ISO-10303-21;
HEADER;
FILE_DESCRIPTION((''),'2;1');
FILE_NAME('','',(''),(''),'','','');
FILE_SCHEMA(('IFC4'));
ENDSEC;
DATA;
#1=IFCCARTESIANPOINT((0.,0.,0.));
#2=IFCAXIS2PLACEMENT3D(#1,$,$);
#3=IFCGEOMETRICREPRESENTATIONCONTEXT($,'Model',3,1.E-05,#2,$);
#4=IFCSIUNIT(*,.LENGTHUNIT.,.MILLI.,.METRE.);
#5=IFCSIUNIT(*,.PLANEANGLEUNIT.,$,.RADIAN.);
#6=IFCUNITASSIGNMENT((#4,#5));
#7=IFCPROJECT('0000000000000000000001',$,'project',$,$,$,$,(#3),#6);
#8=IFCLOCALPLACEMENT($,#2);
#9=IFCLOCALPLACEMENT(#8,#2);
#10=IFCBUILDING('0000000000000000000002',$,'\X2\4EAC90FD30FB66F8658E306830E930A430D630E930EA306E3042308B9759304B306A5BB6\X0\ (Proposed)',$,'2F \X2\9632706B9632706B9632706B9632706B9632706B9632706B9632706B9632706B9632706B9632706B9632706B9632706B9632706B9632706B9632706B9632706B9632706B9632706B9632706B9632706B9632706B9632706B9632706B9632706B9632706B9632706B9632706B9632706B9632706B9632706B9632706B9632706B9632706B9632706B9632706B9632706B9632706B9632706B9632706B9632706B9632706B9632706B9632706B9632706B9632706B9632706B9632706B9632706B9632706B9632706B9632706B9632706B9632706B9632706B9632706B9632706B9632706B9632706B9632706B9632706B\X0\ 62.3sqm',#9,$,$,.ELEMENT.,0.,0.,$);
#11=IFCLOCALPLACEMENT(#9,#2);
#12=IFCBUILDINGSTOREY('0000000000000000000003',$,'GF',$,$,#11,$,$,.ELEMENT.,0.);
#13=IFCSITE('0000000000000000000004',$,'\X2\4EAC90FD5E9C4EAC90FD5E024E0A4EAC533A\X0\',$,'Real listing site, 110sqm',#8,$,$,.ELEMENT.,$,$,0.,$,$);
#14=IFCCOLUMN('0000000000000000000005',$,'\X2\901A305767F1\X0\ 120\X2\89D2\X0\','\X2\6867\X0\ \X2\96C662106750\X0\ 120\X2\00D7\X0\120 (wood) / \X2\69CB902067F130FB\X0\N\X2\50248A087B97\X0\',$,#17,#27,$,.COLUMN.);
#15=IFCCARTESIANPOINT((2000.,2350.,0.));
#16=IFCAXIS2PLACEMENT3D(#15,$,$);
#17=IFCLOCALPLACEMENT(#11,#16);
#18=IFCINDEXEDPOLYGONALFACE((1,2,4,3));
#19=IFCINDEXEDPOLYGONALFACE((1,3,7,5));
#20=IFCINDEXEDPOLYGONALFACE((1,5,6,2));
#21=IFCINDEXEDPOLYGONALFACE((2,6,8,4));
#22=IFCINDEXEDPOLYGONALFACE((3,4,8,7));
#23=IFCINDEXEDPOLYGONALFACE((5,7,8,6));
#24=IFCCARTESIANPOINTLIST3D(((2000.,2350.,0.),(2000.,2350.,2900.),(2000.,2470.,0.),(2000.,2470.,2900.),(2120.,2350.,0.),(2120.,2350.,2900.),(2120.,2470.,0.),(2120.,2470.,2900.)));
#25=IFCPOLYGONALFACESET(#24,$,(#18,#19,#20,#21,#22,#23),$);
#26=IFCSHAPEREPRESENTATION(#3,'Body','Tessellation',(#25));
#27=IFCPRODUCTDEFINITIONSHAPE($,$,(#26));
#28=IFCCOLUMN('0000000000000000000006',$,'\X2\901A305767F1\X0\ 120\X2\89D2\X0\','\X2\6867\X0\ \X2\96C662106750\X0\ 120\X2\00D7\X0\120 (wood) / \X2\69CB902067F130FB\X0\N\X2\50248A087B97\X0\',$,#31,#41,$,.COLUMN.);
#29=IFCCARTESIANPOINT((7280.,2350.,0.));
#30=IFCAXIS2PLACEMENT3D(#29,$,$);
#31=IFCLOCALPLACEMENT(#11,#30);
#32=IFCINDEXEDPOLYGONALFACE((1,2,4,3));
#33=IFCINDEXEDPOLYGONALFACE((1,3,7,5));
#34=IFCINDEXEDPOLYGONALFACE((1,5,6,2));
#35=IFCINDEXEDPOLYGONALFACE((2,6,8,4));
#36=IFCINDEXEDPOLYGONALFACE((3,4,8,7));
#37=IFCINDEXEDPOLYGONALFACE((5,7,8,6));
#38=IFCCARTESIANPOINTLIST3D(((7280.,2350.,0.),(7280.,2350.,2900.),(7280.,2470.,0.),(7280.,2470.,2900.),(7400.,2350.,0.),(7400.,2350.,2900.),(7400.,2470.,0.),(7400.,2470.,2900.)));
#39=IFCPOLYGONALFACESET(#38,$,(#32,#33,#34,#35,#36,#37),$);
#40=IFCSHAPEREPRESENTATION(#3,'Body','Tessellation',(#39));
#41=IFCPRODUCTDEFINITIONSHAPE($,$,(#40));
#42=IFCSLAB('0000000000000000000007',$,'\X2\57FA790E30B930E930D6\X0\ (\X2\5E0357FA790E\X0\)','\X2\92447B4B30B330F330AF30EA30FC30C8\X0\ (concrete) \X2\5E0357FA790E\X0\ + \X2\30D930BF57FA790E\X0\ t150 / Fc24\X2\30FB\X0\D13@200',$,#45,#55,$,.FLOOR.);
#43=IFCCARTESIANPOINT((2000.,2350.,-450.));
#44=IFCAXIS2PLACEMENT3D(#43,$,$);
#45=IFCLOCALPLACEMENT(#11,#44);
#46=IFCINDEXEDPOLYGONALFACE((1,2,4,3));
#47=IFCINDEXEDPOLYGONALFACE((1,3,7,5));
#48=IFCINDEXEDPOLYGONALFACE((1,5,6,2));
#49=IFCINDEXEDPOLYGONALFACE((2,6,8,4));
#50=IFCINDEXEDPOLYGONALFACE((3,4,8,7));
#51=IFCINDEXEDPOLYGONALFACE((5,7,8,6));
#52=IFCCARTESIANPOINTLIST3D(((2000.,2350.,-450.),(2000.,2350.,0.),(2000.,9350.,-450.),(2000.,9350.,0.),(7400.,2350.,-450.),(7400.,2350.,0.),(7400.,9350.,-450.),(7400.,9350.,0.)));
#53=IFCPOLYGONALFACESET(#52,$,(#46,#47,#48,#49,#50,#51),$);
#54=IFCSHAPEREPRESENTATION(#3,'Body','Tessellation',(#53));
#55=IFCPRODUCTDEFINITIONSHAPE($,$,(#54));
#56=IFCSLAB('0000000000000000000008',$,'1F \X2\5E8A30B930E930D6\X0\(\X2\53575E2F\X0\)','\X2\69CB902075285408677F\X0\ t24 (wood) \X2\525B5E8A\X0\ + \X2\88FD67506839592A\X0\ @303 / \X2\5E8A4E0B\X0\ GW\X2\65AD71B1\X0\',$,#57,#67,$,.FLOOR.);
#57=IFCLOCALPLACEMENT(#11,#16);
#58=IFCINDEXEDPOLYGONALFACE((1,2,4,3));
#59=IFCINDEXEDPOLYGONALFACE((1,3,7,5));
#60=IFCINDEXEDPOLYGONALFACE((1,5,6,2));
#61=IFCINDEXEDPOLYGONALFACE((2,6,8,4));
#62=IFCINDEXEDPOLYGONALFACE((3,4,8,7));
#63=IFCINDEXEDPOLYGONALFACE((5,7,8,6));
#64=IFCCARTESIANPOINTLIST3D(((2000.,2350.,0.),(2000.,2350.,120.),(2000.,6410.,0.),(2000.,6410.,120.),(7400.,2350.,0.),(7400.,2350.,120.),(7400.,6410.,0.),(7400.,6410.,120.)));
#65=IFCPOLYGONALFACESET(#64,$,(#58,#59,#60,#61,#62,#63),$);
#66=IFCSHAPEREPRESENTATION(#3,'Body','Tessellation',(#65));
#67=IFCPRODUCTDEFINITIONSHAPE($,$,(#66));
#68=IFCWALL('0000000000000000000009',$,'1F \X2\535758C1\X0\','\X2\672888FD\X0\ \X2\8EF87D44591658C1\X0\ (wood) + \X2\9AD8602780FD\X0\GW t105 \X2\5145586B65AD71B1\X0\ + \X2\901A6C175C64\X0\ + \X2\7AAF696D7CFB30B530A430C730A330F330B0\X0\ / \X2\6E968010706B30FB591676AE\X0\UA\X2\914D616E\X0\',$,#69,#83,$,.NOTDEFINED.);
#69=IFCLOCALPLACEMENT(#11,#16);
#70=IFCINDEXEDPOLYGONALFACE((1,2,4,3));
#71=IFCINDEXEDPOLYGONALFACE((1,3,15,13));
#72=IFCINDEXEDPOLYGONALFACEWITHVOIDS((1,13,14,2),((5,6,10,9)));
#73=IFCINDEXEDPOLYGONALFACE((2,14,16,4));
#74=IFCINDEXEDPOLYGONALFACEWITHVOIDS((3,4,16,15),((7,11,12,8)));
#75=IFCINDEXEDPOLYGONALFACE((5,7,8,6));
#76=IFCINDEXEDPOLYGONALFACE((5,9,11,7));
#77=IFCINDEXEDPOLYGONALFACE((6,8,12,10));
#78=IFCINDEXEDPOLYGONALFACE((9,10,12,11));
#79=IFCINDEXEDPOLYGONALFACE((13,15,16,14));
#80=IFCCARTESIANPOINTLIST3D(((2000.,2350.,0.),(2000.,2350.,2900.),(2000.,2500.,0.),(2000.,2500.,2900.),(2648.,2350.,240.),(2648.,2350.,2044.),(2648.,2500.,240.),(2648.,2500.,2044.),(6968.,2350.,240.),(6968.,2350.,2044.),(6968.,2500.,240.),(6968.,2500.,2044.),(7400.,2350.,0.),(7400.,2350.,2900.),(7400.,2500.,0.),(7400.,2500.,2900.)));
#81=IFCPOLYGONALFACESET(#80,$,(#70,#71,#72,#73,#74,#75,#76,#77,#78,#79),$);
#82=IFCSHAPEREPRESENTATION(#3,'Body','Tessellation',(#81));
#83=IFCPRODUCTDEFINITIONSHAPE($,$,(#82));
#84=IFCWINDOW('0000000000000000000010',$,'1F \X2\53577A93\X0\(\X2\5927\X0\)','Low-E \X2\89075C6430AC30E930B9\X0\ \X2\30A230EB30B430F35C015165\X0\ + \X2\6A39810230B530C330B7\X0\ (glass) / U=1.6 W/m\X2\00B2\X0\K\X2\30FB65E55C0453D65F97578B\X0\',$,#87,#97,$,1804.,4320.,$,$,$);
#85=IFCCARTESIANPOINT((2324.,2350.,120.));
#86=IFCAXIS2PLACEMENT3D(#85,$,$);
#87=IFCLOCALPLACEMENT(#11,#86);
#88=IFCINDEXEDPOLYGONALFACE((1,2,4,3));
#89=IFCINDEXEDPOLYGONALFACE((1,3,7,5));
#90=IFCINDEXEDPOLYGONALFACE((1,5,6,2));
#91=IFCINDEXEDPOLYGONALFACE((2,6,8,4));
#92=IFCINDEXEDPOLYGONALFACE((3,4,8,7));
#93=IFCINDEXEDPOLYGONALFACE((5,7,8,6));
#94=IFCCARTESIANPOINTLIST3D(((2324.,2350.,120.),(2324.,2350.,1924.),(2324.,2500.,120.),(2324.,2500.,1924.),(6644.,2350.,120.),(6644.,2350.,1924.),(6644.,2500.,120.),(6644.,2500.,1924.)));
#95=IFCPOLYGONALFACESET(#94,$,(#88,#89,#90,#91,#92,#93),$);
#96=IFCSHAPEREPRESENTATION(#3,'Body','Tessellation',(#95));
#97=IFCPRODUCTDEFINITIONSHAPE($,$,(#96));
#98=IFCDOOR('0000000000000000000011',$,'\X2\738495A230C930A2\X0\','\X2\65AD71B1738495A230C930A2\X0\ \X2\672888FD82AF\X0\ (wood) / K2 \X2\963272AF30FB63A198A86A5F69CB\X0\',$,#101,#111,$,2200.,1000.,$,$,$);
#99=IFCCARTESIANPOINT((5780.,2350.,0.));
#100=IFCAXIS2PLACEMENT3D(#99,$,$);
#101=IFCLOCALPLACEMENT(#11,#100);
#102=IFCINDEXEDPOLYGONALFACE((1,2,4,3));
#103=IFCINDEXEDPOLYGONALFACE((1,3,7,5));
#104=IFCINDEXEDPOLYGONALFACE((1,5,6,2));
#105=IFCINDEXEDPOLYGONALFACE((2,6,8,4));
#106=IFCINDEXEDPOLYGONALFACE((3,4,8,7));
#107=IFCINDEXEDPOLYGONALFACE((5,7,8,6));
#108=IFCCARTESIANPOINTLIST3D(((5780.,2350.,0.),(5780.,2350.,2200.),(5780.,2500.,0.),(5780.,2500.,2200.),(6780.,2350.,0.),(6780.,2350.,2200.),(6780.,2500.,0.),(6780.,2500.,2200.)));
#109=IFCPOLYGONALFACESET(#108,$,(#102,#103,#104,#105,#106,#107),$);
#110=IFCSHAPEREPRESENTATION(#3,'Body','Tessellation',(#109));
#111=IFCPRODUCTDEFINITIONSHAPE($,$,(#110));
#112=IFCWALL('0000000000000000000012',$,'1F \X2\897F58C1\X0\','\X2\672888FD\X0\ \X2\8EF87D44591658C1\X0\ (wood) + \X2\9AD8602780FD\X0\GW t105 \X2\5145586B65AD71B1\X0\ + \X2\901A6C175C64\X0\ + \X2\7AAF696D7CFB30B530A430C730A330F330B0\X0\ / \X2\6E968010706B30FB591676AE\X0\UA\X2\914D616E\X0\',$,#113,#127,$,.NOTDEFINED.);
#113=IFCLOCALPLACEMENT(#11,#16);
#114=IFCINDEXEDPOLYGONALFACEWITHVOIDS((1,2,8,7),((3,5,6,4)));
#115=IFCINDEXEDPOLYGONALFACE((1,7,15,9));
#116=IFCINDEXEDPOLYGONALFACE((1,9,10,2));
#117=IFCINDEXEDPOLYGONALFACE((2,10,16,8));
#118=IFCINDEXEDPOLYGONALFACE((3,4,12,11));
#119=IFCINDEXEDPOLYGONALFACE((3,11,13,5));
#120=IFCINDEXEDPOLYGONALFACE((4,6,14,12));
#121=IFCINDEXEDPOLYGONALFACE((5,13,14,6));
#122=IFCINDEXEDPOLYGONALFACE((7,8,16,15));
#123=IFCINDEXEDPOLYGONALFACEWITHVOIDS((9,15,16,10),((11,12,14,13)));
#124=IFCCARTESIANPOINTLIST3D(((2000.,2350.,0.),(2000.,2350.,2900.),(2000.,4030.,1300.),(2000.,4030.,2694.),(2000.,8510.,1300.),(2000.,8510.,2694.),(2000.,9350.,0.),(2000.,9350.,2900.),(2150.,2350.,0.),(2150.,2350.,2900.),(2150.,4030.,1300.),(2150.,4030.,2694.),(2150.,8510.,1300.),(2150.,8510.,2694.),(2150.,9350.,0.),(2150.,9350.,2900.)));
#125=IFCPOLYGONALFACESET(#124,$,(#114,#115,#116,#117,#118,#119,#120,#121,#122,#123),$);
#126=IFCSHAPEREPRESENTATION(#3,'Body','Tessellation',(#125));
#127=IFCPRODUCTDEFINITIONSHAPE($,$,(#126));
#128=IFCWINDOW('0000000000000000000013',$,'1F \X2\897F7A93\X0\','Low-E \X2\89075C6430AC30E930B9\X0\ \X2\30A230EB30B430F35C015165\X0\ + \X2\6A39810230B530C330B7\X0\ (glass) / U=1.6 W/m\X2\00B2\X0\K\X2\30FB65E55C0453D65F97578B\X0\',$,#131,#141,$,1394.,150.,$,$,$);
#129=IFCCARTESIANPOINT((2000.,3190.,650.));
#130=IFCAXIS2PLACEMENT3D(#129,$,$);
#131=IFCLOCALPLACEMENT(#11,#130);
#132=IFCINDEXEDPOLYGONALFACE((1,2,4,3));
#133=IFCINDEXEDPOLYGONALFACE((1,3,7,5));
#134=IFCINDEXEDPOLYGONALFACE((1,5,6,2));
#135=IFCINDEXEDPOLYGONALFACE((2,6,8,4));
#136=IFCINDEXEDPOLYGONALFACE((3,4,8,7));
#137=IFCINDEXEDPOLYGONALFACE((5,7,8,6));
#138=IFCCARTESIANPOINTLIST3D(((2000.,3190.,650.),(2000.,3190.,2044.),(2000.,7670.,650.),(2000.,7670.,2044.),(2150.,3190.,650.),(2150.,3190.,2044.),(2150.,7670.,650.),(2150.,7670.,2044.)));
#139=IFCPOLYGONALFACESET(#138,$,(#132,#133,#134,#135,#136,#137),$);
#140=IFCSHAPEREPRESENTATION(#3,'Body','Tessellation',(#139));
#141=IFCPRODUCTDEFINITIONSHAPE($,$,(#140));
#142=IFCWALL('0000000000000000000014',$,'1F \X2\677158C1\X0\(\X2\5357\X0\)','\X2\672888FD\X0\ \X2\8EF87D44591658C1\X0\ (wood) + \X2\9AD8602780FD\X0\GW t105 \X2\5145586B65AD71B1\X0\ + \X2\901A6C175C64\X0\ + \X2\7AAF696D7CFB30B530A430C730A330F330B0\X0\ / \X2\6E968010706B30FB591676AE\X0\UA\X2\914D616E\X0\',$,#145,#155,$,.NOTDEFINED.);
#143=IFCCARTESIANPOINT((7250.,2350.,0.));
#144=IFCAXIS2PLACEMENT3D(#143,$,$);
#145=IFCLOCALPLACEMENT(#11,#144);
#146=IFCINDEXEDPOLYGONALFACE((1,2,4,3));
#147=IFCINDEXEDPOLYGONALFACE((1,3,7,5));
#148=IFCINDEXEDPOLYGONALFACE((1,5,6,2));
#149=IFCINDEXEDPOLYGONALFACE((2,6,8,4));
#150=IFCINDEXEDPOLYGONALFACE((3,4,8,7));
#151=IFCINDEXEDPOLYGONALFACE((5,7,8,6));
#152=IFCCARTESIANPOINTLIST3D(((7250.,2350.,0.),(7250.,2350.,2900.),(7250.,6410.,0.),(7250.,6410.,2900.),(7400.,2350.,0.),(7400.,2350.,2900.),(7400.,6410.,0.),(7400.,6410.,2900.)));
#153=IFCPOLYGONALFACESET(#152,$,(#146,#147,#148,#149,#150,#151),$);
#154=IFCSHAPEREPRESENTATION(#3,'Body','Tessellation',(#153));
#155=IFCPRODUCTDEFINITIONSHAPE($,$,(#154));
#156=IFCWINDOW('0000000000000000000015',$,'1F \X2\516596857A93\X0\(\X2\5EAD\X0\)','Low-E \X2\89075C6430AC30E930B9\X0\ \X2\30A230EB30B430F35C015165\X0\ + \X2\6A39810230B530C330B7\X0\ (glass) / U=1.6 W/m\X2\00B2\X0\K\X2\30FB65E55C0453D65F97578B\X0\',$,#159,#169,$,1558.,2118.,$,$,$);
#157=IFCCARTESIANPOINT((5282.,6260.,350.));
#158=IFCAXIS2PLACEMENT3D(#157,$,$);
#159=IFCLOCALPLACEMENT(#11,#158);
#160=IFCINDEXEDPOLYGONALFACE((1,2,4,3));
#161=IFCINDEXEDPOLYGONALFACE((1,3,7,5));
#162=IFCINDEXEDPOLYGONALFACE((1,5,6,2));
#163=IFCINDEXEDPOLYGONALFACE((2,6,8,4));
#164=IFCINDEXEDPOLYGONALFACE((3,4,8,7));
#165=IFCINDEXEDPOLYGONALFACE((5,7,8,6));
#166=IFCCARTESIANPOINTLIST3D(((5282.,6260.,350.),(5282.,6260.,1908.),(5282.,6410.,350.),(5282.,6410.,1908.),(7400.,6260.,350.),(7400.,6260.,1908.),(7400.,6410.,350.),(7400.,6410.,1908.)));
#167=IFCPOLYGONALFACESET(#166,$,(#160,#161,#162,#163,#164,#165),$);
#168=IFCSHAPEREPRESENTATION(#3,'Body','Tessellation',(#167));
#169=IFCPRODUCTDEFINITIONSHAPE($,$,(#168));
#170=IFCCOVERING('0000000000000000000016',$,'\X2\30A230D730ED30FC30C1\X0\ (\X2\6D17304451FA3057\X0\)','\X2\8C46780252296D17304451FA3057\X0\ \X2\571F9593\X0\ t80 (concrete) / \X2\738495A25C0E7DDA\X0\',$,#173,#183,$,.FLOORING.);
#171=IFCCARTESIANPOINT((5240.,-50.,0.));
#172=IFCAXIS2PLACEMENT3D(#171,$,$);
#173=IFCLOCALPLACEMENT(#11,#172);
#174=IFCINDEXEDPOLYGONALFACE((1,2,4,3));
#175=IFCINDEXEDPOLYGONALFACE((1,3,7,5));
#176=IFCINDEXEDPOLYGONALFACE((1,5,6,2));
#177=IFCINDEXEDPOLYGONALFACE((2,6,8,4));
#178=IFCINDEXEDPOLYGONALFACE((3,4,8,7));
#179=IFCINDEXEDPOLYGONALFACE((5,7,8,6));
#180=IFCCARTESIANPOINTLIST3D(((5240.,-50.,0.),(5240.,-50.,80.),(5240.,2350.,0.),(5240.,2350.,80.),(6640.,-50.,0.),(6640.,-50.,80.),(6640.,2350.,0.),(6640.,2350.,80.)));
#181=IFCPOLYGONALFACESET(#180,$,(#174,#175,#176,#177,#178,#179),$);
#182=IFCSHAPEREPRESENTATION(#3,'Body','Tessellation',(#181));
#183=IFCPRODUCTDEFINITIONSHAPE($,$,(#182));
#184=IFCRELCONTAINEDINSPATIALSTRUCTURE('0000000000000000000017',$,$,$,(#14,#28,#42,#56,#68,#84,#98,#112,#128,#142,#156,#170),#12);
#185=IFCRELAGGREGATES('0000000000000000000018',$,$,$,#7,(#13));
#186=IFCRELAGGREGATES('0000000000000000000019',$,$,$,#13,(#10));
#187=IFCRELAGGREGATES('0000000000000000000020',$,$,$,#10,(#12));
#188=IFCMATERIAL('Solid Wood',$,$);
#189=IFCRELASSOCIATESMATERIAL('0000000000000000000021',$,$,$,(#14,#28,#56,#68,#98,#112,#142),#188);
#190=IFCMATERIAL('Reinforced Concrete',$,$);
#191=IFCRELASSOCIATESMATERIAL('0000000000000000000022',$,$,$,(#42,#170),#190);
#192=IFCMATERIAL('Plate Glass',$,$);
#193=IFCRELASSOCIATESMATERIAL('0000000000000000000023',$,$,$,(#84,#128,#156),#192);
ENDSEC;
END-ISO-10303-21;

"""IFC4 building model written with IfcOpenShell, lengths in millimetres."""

from ifc_helpers import new_model, si_unit, frame, frame_2d, origin, place, context, project, spatial, rectangle, extrude, material, element, fill, save


model = new_model("IFC4")

# Units and contexts
model_context = context("Model", 3, precision=1e-05, world=origin())
ifc_project = project(units=[si_unit("LENGTHUNIT", "METRE", prefix="MILLI"), si_unit("PLANEANGLEUNIT", "RADIAN")], contexts=[model_context])

# Site, building, storey
site_placement = place(None, origin())
site = spatial("IfcSite", under=ifc_project, at=site_placement, Name="京都府京都市上京区", ObjectType="Real listing site, 110sqm", CompositionType="ELEMENT", RefElevation=0.0)
building_placement = place(site_placement, origin())
building = spatial("IfcBuilding", under=site, at=building_placement, Name="京都・書斎とライブラリのある静かな家 (Proposed)", ObjectType="2F 防火防火防火防火防火防火防火防火防火防火防火防火防火防火防火防火防火防火防火防火防火防火防火防火防火防火防火防火防火防火防火防火防火防火防火防火防火防火防火防火防火防火防火防火防火防火防火防火防火防火防火防火防火防火防火防火防火防火防火防火 62.3sqm", CompositionType="ELEMENT", ElevationOfRefHeight=0.0, ElevationOfTerrain=0.0)
storey_placement = place(building_placement, origin())
storey = spatial("IfcBuildingStorey", under=building, at=storey_placement, Name="GF", CompositionType="ELEMENT", Elevation=0.0)

# Columns
ifc_material_1 = material(Name="Solid Wood")
column_1_placement = place(storey_placement, frame((2000.0, 2350.0, 0.0)))
element("IfcColumn", 1, at=column_1_placement, inside=storey, material=ifc_material_1, Name="通し柱 120角", Description="桧 集成材 120×120 (wood) / 構造柱・N値計算", PredefinedType="COLUMN", context=model_context, shape_type="SweptSolid", body=[
    extrude(rectangle(XDim=120.0, YDim=120.0, at=frame_2d((60.0, 60.0))), frame((2000.0, 2350.0, 0.0)), (0.0, 0.0, 1.0), 2900.0),
])
column_2_placement = place(storey_placement, frame((7280.0, 2350.0, 0.0)))
element("IfcColumn", 2, at=column_2_placement, inside=storey, material=ifc_material_1, Name="通し柱 120角", Description="桧 集成材 120×120 (wood) / 構造柱・N値計算", PredefinedType="COLUMN", context=model_context, shape_type="SweptSolid", body=[
    extrude(rectangle(XDim=120.0, YDim=120.0, at=frame_2d((60.0, 60.0))), frame((7280.0, 2350.0, 0.0)), (0.0, 0.0, 1.0), 2900.0),
])

# Slabs
ifc_material_2 = material(Name="Reinforced Concrete")
slab_1_placement = place(storey_placement, frame((2000.0, 2350.0, -450.0)))
element("IfcSlab", 3, at=slab_1_placement, inside=storey, material=ifc_material_2, Name="基礎スラブ (布基礎)", Description="鉄筋コンクリート (concrete) 布基礎 + ベタ基礎 t150 / Fc24・D13@200", PredefinedType="FLOOR", context=model_context, shape_type="SweptSolid", body=[
    extrude(rectangle(XDim=5400.0, YDim=7000.0, at=frame_2d((2700.0, 3500.0))), frame((2000.0, 2350.0, -450.0)), (0.0, 0.0, 1.0), 450.0),
])
slab_2_placement = place(storey_placement, frame((2000.0, 2350.0, 0.0)))
element("IfcSlab", 4, at=slab_2_placement, inside=storey, material=ifc_material_1, Name="1F 床スラブ(南帯)", Description="構造用合板 t24 (wood) 剛床 + 製材根太 @303 / 床下 GW断熱", PredefinedType="FLOOR", context=model_context, shape_type="SweptSolid", body=[
    extrude(rectangle(XDim=5400.0, YDim=4060.0, at=frame_2d((2700.0, 2030.0))), frame((2000.0, 2350.0, 0.0)), (0.0, 0.0, 1.0), 120.0),
])

# Wall, openings, window, door
wall_1_placement = place(storey_placement, frame((2000.0, 2350.0, 0.0)))
wall_1 = element("IfcWall", 5, at=wall_1_placement, inside=storey, material=ifc_material_1, Name="1F 南壁", Description="木製 軸組外壁 (wood) + 高性能GW t105 充填断熱 + 通気層 + 窯業系サイディング / 準耐火・外皮UA配慮", PredefinedType="NOTDEFINED", context=model_context, shape_type="SweptSolid", body=[
    extrude(rectangle(XDim=5400.0, YDim=150.0, at=frame_2d((2700.0, 75.0))), frame((2000.0, 2350.0, 0.0)), (0.0, 0.0, 1.0), 2900.0),
])
opening_1_placement = place(storey_placement, frame((2324.0, 2350.0, 120.0)))
opening_1 = element("IfcOpeningElement", 6, at=opening_1_placement, cuts=wall_1, PredefinedType="NOTDEFINED", context=model_context, shape_type="SweptSolid", body=[
    extrude(rectangle(XDim=4320.0, YDim=150.0, at=frame_2d((2160.0, 75.0))), frame((2324.0, 2350.0, 120.0)), (0.0, 0.0, 1.0), 1804.0),
])
opening_2_placement = place(storey_placement, frame((5780.0, 2350.0, 0.0)))
opening_2 = element("IfcOpeningElement", 7, at=opening_2_placement, cuts=wall_1, PredefinedType="NOTDEFINED", context=model_context, shape_type="SweptSolid", body=[
    extrude(rectangle(XDim=1000.0, YDim=150.0, at=frame_2d((500.0, 75.0))), frame((5780.0, 2350.0, 0.0)), (0.0, 0.0, 1.0), 2200.0),
])
ifc_material_3 = material(Name="Plate Glass")
window_1_placement = place(storey_placement, frame((2324.0, 2350.0, 120.0)))
window_1 = element("IfcWindow", 8, at=window_1_placement, inside=storey, material=ifc_material_3, Name="1F 南窓(大)", Description="Low-E 複層ガラス アルゴン封入 + 樹脂サッシ (glass) / U=1.6 W/m²K・日射取得型", OverallHeight=1804.0, OverallWidth=4320.0, context=model_context, shape_type="SweptSolid", body=[
    extrude(rectangle(XDim=4320.0, YDim=150.0, at=frame_2d((2160.0, 75.0))), frame((2324.0, 2350.0, 120.0)), (0.0, 0.0, 1.0), 1804.0),
])
fill(opening_1, window_1)
door_1_placement = place(storey_placement, frame((5780.0, 2350.0, 0.0)))
door_1 = element("IfcDoor", 9, at=door_1_placement, inside=storey, material=ifc_material_1, Name="玄関ドア", Description="断熱玄関ドア 木製芯 (wood) / K2 防犯・採風機構", OverallHeight=2200.0, OverallWidth=1000.0, context=model_context, shape_type="SweptSolid", body=[
    extrude(rectangle(XDim=1000.0, YDim=150.0, at=frame_2d((500.0, 75.0))), frame((5780.0, 2350.0, 0.0)), (0.0, 0.0, 1.0), 2200.0),
])
fill(opening_2, door_1)

# Walls, openings, windows
wall_2_placement = place(storey_placement, frame((2000.0, 2350.0, 0.0)))
wall_2 = element("IfcWall", 10, at=wall_2_placement, inside=storey, material=ifc_material_1, Name="1F 西壁", Description="木製 軸組外壁 (wood) + 高性能GW t105 充填断熱 + 通気層 + 窯業系サイディング / 準耐火・外皮UA配慮", PredefinedType="NOTDEFINED", context=model_context, shape_type="SweptSolid", body=[
    extrude(rectangle(XDim=150.0, YDim=7000.0, at=frame_2d((75.0, 3500.0))), frame((2000.0, 2350.0, 0.0)), (0.0, 0.0, 1.0), 2900.0),
])
opening_3_placement = place(storey_placement, frame((2000.0, 3190.0, 650.0)))
opening_3 = element("IfcOpeningElement", 11, at=opening_3_placement, cuts=wall_2, PredefinedType="NOTDEFINED", context=model_context, shape_type="SweptSolid", body=[
    extrude(rectangle(XDim=150.0, YDim=4480.0, at=frame_2d((75.0, 2240.0))), frame((2000.0, 3190.0, 650.0)), (0.0, 0.0, 1.0), 1394.0),
])
window_2_placement = place(storey_placement, frame((2000.0, 3190.0, 650.0)))
window_2 = element("IfcWindow", 12, at=window_2_placement, inside=storey, material=ifc_material_3, Name="1F 西窓", Description="Low-E 複層ガラス アルゴン封入 + 樹脂サッシ (glass) / U=1.6 W/m²K・日射取得型", OverallHeight=1394.0, OverallWidth=150.0, context=model_context, shape_type="SweptSolid", body=[
    extrude(rectangle(XDim=150.0, YDim=4480.0, at=frame_2d((75.0, 2240.0))), frame((2000.0, 3190.0, 650.0)), (0.0, 0.0, 1.0), 1394.0),
])
fill(opening_3, window_2)
wall_3_placement = place(storey_placement, frame((7250.0, 2350.0, 0.0)))
wall_3 = element("IfcWall", 13, at=wall_3_placement, inside=storey, material=ifc_material_1, Name="1F 東壁(南)", Description="木製 軸組外壁 (wood) + 高性能GW t105 充填断熱 + 通気層 + 窯業系サイディング / 準耐火・外皮UA配慮", PredefinedType="NOTDEFINED", context=model_context, shape_type="SweptSolid", body=[
    extrude(rectangle(XDim=150.0, YDim=4060.0, at=frame_2d((75.0, 2030.0))), frame((7250.0, 2350.0, 0.0)), (0.0, 0.0, 1.0), 2900.0),
])
opening_4_placement = place(storey_placement, frame((5282.0, 6260.0, 350.0)))
opening_4 = element("IfcOpeningElement", 14, at=opening_4_placement, cuts=wall_3, PredefinedType="NOTDEFINED", context=model_context, shape_type="SweptSolid", body=[
    extrude(rectangle(XDim=2118.0, YDim=150.0, at=frame_2d((1059.0, 75.0))), frame((5282.0, 6260.0, 350.0)), (0.0, 0.0, 1.0), 1558.0),
])
window_3_placement = place(storey_placement, frame((5282.0, 6260.0, 350.0)))
window_3 = element("IfcWindow", 15, at=window_3_placement, inside=storey, material=ifc_material_3, Name="1F 入隅窓(庭)", Description="Low-E 複層ガラス アルゴン封入 + 樹脂サッシ (glass) / U=1.6 W/m²K・日射取得型", OverallHeight=1558.0, OverallWidth=2118.0, context=model_context, shape_type="SweptSolid", body=[
    extrude(rectangle(XDim=2118.0, YDim=150.0, at=frame_2d((1059.0, 75.0))), frame((5282.0, 6260.0, 350.0)), (0.0, 0.0, 1.0), 1558.0),
])
fill(opening_4, window_3)

# Covering
covering_1_placement = place(storey_placement, frame((5240.0, -50.0, 0.0)))
element("IfcCovering", 16, at=covering_1_placement, inside=storey, material=ifc_material_2, Name="アプローチ (洗い出し)", Description="豆砂利洗い出し 土間 t80 (concrete) / 玄関導線", PredefinedType="FLOORING", context=model_context, shape_type="SweptSolid", body=[
    extrude(rectangle(XDim=1400.0, YDim=2400.0, at=frame_2d((700.0, 1200.0))), frame((5240.0, -50.0, 0.0)), (0.0, 0.0, 1.0), 80.0),
])

save(model, "model.ifc")
